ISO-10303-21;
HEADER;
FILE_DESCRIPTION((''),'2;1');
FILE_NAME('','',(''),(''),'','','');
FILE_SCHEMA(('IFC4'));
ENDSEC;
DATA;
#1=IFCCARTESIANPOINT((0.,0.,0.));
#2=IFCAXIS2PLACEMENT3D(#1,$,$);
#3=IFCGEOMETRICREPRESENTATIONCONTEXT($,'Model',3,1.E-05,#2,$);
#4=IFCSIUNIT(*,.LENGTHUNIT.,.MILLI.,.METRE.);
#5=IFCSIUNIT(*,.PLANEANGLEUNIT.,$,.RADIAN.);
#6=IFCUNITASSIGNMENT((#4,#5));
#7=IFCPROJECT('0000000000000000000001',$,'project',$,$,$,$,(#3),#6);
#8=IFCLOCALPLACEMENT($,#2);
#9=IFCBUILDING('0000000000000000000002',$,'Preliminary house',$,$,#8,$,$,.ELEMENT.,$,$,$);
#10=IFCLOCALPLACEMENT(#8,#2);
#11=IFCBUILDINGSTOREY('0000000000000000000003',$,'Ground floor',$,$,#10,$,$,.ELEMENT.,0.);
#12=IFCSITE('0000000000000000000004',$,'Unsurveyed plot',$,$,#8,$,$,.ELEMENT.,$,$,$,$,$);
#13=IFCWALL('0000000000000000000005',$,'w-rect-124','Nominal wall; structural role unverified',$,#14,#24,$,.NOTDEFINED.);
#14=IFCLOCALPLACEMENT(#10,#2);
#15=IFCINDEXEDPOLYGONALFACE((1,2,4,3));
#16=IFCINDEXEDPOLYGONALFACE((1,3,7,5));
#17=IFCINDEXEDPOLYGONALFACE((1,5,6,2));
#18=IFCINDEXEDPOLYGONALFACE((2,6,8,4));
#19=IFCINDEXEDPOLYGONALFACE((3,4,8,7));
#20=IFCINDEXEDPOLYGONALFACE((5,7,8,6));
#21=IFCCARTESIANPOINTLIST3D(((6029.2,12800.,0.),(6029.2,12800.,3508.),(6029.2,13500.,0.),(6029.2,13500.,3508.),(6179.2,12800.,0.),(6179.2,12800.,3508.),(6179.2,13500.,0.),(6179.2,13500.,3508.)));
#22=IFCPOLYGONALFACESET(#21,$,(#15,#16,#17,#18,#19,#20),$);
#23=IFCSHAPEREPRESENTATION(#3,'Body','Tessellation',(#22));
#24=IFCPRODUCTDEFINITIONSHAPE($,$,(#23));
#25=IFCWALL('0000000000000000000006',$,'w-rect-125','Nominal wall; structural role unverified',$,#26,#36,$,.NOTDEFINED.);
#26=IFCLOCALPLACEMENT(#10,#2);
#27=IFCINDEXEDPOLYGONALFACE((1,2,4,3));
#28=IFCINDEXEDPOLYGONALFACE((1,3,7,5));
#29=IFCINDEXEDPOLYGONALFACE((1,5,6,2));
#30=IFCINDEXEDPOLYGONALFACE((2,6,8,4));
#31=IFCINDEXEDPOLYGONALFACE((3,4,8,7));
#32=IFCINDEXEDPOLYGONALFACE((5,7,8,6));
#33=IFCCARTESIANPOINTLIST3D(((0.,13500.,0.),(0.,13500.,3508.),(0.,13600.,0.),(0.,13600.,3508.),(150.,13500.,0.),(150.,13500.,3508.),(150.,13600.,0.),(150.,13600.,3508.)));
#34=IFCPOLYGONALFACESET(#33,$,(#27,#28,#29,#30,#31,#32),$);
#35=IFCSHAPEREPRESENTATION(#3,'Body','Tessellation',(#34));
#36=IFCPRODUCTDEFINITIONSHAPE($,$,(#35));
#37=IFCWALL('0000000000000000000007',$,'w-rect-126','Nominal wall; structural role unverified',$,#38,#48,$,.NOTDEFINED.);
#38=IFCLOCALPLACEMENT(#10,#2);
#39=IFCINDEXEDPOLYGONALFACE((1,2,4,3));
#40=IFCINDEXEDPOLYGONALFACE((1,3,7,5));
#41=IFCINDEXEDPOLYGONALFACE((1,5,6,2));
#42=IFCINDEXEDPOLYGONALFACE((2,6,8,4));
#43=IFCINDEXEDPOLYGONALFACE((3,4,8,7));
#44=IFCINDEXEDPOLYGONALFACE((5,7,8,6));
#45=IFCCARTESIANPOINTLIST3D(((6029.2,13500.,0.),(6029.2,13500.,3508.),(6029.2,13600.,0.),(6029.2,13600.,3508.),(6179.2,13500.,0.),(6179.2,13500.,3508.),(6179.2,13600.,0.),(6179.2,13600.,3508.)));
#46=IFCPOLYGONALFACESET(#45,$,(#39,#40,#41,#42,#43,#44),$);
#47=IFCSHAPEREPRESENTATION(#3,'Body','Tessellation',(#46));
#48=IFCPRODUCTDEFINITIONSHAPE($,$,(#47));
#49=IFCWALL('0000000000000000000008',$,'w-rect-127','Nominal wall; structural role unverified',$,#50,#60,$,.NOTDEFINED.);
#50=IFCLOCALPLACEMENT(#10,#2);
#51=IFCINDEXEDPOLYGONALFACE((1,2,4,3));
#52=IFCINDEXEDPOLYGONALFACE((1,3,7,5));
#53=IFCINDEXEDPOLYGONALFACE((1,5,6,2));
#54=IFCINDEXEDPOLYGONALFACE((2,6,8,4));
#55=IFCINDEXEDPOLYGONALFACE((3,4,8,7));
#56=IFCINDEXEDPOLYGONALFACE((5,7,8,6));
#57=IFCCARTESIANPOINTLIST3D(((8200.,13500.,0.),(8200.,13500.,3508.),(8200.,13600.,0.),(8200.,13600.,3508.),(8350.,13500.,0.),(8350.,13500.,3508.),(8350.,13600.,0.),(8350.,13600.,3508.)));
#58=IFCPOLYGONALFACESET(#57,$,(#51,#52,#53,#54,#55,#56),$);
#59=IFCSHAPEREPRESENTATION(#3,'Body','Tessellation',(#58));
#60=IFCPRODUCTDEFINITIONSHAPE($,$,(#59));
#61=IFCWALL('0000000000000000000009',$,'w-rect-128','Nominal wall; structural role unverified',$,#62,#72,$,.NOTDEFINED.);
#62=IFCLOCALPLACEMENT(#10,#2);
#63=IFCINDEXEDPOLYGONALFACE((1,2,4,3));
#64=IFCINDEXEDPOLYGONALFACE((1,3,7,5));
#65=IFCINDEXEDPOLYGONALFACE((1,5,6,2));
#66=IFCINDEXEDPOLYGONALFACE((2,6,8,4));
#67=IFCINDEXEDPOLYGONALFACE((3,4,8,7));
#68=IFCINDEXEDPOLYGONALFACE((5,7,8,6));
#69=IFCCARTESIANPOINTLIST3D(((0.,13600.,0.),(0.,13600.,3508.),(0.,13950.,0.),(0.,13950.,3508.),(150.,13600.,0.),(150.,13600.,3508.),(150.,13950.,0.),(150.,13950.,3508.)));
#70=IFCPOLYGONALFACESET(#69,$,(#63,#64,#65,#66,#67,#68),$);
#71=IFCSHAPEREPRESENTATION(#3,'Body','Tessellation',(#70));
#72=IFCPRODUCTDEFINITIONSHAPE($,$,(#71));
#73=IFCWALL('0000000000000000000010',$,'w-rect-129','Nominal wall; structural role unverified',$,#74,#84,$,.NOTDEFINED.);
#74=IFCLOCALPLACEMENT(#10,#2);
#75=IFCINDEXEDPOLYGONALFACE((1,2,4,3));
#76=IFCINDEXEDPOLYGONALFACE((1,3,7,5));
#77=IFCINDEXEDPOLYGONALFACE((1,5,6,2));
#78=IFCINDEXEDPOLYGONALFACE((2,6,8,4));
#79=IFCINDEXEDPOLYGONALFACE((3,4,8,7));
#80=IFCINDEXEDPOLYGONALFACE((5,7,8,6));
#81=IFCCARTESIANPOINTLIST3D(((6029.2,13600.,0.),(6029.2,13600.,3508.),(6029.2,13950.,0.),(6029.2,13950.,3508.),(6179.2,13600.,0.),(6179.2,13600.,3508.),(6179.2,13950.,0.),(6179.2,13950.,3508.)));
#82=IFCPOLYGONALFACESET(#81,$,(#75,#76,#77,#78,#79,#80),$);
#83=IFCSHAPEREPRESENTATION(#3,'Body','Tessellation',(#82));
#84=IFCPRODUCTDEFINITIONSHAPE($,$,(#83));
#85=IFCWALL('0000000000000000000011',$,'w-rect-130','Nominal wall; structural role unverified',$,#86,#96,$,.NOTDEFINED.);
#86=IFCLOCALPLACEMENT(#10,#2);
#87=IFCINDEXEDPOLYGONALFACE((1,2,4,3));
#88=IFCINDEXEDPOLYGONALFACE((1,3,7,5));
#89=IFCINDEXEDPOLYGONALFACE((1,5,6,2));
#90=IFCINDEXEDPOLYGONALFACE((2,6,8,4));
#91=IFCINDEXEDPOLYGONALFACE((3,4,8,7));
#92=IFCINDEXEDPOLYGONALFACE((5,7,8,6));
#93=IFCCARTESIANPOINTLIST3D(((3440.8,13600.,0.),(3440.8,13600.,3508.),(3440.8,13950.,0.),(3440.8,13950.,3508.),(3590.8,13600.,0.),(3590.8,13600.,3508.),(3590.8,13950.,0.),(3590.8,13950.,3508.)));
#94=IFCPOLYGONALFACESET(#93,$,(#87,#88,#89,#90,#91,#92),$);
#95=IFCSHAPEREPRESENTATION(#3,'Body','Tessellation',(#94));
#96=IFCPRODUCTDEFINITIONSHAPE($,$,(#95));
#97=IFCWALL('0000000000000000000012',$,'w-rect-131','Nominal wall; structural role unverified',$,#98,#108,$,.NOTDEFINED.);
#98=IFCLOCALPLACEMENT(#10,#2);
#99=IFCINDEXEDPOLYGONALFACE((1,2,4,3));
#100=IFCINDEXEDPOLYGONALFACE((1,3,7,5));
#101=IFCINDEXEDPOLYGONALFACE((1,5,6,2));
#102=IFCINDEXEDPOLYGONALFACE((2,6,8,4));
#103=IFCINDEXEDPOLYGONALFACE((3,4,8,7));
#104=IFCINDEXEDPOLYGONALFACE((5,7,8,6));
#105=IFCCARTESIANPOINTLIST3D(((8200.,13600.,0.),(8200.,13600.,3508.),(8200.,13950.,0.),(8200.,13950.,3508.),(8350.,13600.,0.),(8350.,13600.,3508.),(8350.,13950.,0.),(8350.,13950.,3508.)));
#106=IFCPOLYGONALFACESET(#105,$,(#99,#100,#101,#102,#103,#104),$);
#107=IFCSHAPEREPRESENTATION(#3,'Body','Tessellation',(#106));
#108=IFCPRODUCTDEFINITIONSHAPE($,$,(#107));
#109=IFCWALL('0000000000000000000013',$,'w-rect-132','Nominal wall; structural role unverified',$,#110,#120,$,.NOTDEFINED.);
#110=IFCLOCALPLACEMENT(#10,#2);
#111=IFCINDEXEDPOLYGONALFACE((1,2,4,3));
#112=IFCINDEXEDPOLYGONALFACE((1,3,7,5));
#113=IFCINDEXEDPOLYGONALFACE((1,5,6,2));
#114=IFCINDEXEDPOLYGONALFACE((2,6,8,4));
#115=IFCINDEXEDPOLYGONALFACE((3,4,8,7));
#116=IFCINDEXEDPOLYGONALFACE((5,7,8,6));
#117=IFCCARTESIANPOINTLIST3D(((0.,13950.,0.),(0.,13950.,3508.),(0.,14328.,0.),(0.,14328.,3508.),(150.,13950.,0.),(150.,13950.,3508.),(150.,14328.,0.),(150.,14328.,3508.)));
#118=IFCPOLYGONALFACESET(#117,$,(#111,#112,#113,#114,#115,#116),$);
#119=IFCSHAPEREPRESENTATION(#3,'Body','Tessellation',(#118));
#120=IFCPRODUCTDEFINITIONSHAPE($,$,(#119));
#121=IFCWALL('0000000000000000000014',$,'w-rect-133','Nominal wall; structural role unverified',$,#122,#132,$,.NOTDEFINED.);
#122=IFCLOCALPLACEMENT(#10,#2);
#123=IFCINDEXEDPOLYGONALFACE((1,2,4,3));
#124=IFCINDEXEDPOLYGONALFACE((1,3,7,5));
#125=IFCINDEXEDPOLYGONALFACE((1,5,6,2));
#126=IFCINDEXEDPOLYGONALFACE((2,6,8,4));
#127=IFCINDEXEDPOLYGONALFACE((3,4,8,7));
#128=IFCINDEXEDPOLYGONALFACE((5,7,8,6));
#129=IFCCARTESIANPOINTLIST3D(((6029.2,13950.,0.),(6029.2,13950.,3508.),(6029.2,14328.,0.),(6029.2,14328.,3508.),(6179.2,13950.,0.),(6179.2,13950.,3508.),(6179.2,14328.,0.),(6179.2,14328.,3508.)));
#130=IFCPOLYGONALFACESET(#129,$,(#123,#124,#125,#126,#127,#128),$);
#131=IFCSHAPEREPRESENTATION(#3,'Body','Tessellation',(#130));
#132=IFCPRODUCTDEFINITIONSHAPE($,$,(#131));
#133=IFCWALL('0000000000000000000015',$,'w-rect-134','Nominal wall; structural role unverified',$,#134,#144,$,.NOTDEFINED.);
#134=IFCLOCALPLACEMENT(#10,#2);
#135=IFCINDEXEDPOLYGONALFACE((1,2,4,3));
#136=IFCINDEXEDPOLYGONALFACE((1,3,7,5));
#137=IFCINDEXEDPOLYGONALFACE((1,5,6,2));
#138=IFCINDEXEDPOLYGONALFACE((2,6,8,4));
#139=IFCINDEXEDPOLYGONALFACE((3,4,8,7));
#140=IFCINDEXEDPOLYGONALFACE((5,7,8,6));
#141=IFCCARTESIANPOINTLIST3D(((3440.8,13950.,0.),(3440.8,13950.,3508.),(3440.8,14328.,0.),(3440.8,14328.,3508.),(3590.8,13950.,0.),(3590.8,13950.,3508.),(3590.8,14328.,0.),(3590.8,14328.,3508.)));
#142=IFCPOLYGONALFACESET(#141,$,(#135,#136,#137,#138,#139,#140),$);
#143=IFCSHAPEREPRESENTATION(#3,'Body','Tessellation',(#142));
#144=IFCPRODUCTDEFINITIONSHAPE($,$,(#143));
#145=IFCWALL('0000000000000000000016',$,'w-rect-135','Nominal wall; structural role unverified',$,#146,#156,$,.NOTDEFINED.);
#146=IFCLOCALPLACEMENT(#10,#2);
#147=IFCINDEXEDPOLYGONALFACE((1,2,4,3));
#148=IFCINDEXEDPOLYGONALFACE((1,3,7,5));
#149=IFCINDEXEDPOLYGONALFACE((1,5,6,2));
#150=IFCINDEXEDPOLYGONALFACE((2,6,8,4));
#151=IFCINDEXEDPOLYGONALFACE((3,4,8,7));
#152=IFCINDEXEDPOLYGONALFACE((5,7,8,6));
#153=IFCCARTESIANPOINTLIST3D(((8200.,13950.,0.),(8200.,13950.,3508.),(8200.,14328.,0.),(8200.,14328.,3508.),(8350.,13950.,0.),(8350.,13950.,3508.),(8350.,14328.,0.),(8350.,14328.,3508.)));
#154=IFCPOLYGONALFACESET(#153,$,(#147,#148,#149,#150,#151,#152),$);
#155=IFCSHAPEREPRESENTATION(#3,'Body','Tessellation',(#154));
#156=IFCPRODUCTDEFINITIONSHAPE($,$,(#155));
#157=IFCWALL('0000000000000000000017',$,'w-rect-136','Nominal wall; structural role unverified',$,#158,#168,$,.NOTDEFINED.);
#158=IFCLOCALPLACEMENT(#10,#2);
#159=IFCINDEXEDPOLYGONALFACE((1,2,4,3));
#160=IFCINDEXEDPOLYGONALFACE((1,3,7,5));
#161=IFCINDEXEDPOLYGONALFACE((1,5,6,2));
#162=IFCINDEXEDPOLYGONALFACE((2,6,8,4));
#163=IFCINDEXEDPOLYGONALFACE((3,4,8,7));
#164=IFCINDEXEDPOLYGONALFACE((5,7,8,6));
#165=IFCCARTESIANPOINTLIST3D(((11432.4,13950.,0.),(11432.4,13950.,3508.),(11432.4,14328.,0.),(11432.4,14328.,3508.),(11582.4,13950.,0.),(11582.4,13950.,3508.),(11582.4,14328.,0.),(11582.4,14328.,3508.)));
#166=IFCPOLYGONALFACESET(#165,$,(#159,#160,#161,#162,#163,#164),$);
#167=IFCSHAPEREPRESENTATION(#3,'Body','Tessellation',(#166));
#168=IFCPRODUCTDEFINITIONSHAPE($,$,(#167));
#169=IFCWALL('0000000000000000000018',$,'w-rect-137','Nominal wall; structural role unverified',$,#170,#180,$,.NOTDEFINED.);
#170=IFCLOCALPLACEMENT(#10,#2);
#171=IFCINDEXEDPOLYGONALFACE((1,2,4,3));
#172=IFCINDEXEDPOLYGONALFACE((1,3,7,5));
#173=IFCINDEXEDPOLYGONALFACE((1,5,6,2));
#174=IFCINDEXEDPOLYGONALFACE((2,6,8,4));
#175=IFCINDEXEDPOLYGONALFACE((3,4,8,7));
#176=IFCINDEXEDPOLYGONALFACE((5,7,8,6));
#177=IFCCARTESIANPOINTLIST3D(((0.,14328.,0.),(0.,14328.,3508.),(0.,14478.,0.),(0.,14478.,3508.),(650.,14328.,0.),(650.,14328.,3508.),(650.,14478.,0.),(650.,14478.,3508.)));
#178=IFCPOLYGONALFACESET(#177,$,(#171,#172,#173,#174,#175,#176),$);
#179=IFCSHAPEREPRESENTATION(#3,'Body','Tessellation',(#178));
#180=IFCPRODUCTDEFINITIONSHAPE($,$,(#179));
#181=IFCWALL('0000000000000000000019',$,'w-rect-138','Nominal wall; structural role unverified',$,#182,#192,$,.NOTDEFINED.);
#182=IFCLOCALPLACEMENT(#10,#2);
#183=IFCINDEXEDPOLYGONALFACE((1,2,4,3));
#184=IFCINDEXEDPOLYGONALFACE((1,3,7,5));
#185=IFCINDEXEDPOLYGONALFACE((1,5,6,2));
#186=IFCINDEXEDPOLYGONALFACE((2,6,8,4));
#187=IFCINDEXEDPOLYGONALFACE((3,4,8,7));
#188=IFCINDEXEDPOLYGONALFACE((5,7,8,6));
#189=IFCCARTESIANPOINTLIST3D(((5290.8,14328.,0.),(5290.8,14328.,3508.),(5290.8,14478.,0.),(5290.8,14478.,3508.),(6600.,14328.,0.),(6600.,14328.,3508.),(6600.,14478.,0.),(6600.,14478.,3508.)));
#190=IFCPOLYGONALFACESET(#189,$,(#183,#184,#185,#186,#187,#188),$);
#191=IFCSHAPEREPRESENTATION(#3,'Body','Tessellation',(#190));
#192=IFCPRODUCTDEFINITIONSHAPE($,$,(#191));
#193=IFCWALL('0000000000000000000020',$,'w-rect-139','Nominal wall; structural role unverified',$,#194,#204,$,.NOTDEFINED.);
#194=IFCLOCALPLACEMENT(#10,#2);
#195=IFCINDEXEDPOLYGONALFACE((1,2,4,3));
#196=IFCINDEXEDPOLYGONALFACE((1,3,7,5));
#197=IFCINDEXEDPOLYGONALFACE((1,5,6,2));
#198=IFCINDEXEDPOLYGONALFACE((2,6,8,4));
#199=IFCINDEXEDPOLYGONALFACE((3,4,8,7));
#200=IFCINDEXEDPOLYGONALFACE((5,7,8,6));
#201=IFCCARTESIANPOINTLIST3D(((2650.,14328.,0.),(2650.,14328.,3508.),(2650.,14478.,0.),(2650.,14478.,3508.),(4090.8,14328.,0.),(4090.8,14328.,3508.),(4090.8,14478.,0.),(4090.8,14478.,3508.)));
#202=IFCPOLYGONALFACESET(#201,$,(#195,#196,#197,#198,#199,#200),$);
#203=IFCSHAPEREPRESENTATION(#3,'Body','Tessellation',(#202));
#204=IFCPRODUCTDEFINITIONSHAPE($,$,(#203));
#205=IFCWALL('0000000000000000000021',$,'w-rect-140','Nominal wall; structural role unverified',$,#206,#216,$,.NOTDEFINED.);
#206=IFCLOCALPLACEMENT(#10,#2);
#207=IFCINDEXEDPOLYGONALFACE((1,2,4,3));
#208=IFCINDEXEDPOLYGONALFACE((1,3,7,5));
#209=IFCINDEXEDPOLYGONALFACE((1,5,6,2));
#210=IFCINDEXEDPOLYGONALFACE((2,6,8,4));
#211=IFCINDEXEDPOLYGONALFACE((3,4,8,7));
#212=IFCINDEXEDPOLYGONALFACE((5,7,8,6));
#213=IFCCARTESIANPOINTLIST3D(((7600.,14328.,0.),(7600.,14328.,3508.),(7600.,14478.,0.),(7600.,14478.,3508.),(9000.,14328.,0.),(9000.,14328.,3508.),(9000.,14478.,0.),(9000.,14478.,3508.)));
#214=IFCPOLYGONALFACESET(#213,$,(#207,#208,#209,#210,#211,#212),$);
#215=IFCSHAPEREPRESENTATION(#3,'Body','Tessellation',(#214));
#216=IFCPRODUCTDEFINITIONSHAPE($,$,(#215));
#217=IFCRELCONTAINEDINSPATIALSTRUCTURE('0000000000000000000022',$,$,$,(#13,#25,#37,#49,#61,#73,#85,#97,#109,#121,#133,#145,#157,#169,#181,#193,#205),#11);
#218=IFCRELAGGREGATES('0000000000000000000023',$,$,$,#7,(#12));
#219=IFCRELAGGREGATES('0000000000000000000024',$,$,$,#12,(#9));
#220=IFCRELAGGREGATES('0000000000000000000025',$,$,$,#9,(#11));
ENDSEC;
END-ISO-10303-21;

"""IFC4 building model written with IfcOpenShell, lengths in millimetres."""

from ifc_helpers import new_model, si_unit, origin, place, context, project, spatial, polyline, outline, extrude, element, save


model = new_model("IFC4")

# Units and contexts
model_context = context("Model", 3, precision=1e-05, world=origin())
ifc_project = project(units=[si_unit("LENGTHUNIT", "METRE", prefix="MILLI"), si_unit("PLANEANGLEUNIT", "RADIAN")], contexts=[model_context])

# Site, building, storey
placement_1 = place(None, origin())
site = spatial("IfcSite", under=ifc_project, at=placement_1, Name="Unsurveyed plot", CompositionType="ELEMENT")
building = spatial("IfcBuilding", under=site, at=placement_1, Name="Preliminary house", CompositionType="ELEMENT")
placement_2 = place(placement_1, origin())
storey = spatial("IfcBuildingStorey", under=building, at=placement_2, Name="Ground floor", CompositionType="ELEMENT", Elevation=0.0)

# Walls
element("IfcWall", 1, at=placement_2, inside=storey, Name="w-rect-124", Description="Nominal wall; structural role unverified", PredefinedType="NOTDEFINED", context=model_context, shape_type="SweptSolid", body=[
    extrude(outline(polyline([(6029.2, 12800.0), (6179.2, 12800.0), (6179.2, 13500.0), (6029.2, 13500.0), (6029.2, 12800.0)])), origin(), (0.0, 0.0, 1.0), 3508.0),
])
element("IfcWall", 2, at=placement_2, inside=storey, Name="w-rect-125", Description="Nominal wall; structural role unverified", PredefinedType="NOTDEFINED", context=model_context, shape_type="SweptSolid", body=[
    extrude(outline(polyline([(0.0, 13500.0), (150.0, 13500.0), (150.0, 13600.0), (0.0, 13600.0), (0.0, 13500.0)])), origin(), (0.0, 0.0, 1.0), 3508.0),
])
element("IfcWall", 3, at=placement_2, inside=storey, Name="w-rect-126", Description="Nominal wall; structural role unverified", PredefinedType="NOTDEFINED", context=model_context, shape_type="SweptSolid", body=[
    extrude(outline(polyline([(6029.2, 13500.0), (6179.2, 13500.0), (6179.2, 13600.0), (6029.2, 13600.0), (6029.2, 13500.0)])), origin(), (0.0, 0.0, 1.0), 3508.0),
])
element("IfcWall", 4, at=placement_2, inside=storey, Name="w-rect-127", Description="Nominal wall; structural role unverified", PredefinedType="NOTDEFINED", context=model_context, shape_type="SweptSolid", body=[
    extrude(outline(polyline([(8200.0, 13500.0), (8350.0, 13500.0), (8350.0, 13600.0), (8200.0, 13600.0), (8200.0, 13500.0)])), origin(), (0.0, 0.0, 1.0), 3508.0),
])
element("IfcWall", 5, at=placement_2, inside=storey, Name="w-rect-128", Description="Nominal wall; structural role unverified", PredefinedType="NOTDEFINED", context=model_context, shape_type="SweptSolid", body=[
    extrude(outline(polyline([(0.0, 13600.0), (150.0, 13600.0), (150.0, 13950.0), (0.0, 13950.0), (0.0, 13600.0)])), origin(), (0.0, 0.0, 1.0), 3508.0),
])
element("IfcWall", 6, at=placement_2, inside=storey, Name="w-rect-129", Description="Nominal wall; structural role unverified", PredefinedType="NOTDEFINED", context=model_context, shape_type="SweptSolid", body=[
    extrude(outline(polyline([(6029.2, 13600.0), (6179.2, 13600.0), (6179.2, 13950.0), (6029.2, 13950.0), (6029.2, 13600.0)])), origin(), (0.0, 0.0, 1.0), 3508.0),
])
element("IfcWall", 7, at=placement_2, inside=storey, Name="w-rect-130", Description="Nominal wall; structural role unverified", PredefinedType="NOTDEFINED", context=model_context, shape_type="SweptSolid", body=[
    extrude(outline(polyline([(3440.8, 13600.0), (3590.8, 13600.0), (3590.8, 13950.0), (3440.8, 13950.0), (3440.8, 13600.0)])), origin(), (0.0, 0.0, 1.0), 3508.0),
])
element("IfcWall", 8, at=placement_2, inside=storey, Name="w-rect-131", Description="Nominal wall; structural role unverified", PredefinedType="NOTDEFINED", context=model_context, shape_type="SweptSolid", body=[
    extrude(outline(polyline([(8200.0, 13600.0), (8350.0, 13600.0), (8350.0, 13950.0), (8200.0, 13950.0), (8200.0, 13600.0)])), origin(), (0.0, 0.0, 1.0), 3508.0),
])
element("IfcWall", 9, at=placement_2, inside=storey, Name="w-rect-132", Description="Nominal wall; structural role unverified", PredefinedType="NOTDEFINED", context=model_context, shape_type="SweptSolid", body=[
    extrude(outline(polyline([(0.0, 13950.0), (150.0, 13950.0), (150.0, 14328.0), (0.0, 14328.0), (0.0, 13950.0)])), origin(), (0.0, 0.0, 1.0), 3508.0),
])
element("IfcWall", 10, at=placement_2, inside=storey, Name="w-rect-133", Description="Nominal wall; structural role unverified", PredefinedType="NOTDEFINED", context=model_context, shape_type="SweptSolid", body=[
    extrude(outline(polyline([(6029.2, 13950.0), (6179.2, 13950.0), (6179.2, 14328.0), (6029.2, 14328.0), (6029.2, 13950.0)])), origin(), (0.0, 0.0, 1.0), 3508.0),
])
element("IfcWall", 11, at=placement_2, inside=storey, Name="w-rect-134", Description="Nominal wall; structural role unverified", PredefinedType="NOTDEFINED", context=model_context, shape_type="SweptSolid", body=[
    extrude(outline(polyline([(3440.8, 13950.0), (3590.8, 13950.0), (3590.8, 14328.0), (3440.8, 14328.0), (3440.8, 13950.0)])), origin(), (0.0, 0.0, 1.0), 3508.0),
])
element("IfcWall", 12, at=placement_2, inside=storey, Name="w-rect-135", Description="Nominal wall; structural role unverified", PredefinedType="NOTDEFINED", context=model_context, shape_type="SweptSolid", body=[
    extrude(outline(polyline([(8200.0, 13950.0), (8350.0, 13950.0), (8350.0, 14328.0), (8200.0, 14328.0), (8200.0, 13950.0)])), origin(), (0.0, 0.0, 1.0), 3508.0),
])
element("IfcWall", 13, at=placement_2, inside=storey, Name="w-rect-136", Description="Nominal wall; structural role unverified", PredefinedType="NOTDEFINED", context=model_context, shape_type="SweptSolid", body=[
    extrude(outline(polyline([(11432.4, 13950.0), (11582.4, 13950.0), (11582.4, 14328.0), (11432.4, 14328.0), (11432.4, 13950.0)])), origin(), (0.0, 0.0, 1.0), 3508.0),
])
element("IfcWall", 14, at=placement_2, inside=storey, Name="w-rect-137", Description="Nominal wall; structural role unverified", PredefinedType="NOTDEFINED", context=model_context, shape_type="SweptSolid", body=[
    extrude(outline(polyline([(0.0, 14328.0), (650.0, 14328.0), (650.0, 14478.0), (0.0, 14478.0), (0.0, 14328.0)])), origin(), (0.0, 0.0, 1.0), 3508.0),
])
element("IfcWall", 15, at=placement_2, inside=storey, Name="w-rect-138", Description="Nominal wall; structural role unverified", PredefinedType="NOTDEFINED", context=model_context, shape_type="SweptSolid", body=[
    extrude(outline(polyline([(5290.8, 14328.0), (6600.0, 14328.0), (6600.0, 14478.0), (5290.8, 14478.0), (5290.8, 14328.0)])), origin(), (0.0, 0.0, 1.0), 3508.0),
])
element("IfcWall", 16, at=placement_2, inside=storey, Name="w-rect-139", Description="Nominal wall; structural role unverified", PredefinedType="NOTDEFINED", context=model_context, shape_type="SweptSolid", body=[
    extrude(outline(polyline([(2650.0, 14328.0), (4090.8, 14328.0), (4090.8, 14478.0), (2650.0, 14478.0), (2650.0, 14328.0)])), origin(), (0.0, 0.0, 1.0), 3508.0),
])
element("IfcWall", 17, at=placement_2, inside=storey, Name="w-rect-140", Description="Nominal wall; structural role unverified", PredefinedType="NOTDEFINED", context=model_context, shape_type="SweptSolid", body=[
    extrude(outline(polyline([(7600.0, 14328.0), (9000.0, 14328.0), (9000.0, 14478.0), (7600.0, 14478.0), (7600.0, 14328.0)])), origin(), (0.0, 0.0, 1.0), 3508.0),
])

save(model, "model.ifc")
